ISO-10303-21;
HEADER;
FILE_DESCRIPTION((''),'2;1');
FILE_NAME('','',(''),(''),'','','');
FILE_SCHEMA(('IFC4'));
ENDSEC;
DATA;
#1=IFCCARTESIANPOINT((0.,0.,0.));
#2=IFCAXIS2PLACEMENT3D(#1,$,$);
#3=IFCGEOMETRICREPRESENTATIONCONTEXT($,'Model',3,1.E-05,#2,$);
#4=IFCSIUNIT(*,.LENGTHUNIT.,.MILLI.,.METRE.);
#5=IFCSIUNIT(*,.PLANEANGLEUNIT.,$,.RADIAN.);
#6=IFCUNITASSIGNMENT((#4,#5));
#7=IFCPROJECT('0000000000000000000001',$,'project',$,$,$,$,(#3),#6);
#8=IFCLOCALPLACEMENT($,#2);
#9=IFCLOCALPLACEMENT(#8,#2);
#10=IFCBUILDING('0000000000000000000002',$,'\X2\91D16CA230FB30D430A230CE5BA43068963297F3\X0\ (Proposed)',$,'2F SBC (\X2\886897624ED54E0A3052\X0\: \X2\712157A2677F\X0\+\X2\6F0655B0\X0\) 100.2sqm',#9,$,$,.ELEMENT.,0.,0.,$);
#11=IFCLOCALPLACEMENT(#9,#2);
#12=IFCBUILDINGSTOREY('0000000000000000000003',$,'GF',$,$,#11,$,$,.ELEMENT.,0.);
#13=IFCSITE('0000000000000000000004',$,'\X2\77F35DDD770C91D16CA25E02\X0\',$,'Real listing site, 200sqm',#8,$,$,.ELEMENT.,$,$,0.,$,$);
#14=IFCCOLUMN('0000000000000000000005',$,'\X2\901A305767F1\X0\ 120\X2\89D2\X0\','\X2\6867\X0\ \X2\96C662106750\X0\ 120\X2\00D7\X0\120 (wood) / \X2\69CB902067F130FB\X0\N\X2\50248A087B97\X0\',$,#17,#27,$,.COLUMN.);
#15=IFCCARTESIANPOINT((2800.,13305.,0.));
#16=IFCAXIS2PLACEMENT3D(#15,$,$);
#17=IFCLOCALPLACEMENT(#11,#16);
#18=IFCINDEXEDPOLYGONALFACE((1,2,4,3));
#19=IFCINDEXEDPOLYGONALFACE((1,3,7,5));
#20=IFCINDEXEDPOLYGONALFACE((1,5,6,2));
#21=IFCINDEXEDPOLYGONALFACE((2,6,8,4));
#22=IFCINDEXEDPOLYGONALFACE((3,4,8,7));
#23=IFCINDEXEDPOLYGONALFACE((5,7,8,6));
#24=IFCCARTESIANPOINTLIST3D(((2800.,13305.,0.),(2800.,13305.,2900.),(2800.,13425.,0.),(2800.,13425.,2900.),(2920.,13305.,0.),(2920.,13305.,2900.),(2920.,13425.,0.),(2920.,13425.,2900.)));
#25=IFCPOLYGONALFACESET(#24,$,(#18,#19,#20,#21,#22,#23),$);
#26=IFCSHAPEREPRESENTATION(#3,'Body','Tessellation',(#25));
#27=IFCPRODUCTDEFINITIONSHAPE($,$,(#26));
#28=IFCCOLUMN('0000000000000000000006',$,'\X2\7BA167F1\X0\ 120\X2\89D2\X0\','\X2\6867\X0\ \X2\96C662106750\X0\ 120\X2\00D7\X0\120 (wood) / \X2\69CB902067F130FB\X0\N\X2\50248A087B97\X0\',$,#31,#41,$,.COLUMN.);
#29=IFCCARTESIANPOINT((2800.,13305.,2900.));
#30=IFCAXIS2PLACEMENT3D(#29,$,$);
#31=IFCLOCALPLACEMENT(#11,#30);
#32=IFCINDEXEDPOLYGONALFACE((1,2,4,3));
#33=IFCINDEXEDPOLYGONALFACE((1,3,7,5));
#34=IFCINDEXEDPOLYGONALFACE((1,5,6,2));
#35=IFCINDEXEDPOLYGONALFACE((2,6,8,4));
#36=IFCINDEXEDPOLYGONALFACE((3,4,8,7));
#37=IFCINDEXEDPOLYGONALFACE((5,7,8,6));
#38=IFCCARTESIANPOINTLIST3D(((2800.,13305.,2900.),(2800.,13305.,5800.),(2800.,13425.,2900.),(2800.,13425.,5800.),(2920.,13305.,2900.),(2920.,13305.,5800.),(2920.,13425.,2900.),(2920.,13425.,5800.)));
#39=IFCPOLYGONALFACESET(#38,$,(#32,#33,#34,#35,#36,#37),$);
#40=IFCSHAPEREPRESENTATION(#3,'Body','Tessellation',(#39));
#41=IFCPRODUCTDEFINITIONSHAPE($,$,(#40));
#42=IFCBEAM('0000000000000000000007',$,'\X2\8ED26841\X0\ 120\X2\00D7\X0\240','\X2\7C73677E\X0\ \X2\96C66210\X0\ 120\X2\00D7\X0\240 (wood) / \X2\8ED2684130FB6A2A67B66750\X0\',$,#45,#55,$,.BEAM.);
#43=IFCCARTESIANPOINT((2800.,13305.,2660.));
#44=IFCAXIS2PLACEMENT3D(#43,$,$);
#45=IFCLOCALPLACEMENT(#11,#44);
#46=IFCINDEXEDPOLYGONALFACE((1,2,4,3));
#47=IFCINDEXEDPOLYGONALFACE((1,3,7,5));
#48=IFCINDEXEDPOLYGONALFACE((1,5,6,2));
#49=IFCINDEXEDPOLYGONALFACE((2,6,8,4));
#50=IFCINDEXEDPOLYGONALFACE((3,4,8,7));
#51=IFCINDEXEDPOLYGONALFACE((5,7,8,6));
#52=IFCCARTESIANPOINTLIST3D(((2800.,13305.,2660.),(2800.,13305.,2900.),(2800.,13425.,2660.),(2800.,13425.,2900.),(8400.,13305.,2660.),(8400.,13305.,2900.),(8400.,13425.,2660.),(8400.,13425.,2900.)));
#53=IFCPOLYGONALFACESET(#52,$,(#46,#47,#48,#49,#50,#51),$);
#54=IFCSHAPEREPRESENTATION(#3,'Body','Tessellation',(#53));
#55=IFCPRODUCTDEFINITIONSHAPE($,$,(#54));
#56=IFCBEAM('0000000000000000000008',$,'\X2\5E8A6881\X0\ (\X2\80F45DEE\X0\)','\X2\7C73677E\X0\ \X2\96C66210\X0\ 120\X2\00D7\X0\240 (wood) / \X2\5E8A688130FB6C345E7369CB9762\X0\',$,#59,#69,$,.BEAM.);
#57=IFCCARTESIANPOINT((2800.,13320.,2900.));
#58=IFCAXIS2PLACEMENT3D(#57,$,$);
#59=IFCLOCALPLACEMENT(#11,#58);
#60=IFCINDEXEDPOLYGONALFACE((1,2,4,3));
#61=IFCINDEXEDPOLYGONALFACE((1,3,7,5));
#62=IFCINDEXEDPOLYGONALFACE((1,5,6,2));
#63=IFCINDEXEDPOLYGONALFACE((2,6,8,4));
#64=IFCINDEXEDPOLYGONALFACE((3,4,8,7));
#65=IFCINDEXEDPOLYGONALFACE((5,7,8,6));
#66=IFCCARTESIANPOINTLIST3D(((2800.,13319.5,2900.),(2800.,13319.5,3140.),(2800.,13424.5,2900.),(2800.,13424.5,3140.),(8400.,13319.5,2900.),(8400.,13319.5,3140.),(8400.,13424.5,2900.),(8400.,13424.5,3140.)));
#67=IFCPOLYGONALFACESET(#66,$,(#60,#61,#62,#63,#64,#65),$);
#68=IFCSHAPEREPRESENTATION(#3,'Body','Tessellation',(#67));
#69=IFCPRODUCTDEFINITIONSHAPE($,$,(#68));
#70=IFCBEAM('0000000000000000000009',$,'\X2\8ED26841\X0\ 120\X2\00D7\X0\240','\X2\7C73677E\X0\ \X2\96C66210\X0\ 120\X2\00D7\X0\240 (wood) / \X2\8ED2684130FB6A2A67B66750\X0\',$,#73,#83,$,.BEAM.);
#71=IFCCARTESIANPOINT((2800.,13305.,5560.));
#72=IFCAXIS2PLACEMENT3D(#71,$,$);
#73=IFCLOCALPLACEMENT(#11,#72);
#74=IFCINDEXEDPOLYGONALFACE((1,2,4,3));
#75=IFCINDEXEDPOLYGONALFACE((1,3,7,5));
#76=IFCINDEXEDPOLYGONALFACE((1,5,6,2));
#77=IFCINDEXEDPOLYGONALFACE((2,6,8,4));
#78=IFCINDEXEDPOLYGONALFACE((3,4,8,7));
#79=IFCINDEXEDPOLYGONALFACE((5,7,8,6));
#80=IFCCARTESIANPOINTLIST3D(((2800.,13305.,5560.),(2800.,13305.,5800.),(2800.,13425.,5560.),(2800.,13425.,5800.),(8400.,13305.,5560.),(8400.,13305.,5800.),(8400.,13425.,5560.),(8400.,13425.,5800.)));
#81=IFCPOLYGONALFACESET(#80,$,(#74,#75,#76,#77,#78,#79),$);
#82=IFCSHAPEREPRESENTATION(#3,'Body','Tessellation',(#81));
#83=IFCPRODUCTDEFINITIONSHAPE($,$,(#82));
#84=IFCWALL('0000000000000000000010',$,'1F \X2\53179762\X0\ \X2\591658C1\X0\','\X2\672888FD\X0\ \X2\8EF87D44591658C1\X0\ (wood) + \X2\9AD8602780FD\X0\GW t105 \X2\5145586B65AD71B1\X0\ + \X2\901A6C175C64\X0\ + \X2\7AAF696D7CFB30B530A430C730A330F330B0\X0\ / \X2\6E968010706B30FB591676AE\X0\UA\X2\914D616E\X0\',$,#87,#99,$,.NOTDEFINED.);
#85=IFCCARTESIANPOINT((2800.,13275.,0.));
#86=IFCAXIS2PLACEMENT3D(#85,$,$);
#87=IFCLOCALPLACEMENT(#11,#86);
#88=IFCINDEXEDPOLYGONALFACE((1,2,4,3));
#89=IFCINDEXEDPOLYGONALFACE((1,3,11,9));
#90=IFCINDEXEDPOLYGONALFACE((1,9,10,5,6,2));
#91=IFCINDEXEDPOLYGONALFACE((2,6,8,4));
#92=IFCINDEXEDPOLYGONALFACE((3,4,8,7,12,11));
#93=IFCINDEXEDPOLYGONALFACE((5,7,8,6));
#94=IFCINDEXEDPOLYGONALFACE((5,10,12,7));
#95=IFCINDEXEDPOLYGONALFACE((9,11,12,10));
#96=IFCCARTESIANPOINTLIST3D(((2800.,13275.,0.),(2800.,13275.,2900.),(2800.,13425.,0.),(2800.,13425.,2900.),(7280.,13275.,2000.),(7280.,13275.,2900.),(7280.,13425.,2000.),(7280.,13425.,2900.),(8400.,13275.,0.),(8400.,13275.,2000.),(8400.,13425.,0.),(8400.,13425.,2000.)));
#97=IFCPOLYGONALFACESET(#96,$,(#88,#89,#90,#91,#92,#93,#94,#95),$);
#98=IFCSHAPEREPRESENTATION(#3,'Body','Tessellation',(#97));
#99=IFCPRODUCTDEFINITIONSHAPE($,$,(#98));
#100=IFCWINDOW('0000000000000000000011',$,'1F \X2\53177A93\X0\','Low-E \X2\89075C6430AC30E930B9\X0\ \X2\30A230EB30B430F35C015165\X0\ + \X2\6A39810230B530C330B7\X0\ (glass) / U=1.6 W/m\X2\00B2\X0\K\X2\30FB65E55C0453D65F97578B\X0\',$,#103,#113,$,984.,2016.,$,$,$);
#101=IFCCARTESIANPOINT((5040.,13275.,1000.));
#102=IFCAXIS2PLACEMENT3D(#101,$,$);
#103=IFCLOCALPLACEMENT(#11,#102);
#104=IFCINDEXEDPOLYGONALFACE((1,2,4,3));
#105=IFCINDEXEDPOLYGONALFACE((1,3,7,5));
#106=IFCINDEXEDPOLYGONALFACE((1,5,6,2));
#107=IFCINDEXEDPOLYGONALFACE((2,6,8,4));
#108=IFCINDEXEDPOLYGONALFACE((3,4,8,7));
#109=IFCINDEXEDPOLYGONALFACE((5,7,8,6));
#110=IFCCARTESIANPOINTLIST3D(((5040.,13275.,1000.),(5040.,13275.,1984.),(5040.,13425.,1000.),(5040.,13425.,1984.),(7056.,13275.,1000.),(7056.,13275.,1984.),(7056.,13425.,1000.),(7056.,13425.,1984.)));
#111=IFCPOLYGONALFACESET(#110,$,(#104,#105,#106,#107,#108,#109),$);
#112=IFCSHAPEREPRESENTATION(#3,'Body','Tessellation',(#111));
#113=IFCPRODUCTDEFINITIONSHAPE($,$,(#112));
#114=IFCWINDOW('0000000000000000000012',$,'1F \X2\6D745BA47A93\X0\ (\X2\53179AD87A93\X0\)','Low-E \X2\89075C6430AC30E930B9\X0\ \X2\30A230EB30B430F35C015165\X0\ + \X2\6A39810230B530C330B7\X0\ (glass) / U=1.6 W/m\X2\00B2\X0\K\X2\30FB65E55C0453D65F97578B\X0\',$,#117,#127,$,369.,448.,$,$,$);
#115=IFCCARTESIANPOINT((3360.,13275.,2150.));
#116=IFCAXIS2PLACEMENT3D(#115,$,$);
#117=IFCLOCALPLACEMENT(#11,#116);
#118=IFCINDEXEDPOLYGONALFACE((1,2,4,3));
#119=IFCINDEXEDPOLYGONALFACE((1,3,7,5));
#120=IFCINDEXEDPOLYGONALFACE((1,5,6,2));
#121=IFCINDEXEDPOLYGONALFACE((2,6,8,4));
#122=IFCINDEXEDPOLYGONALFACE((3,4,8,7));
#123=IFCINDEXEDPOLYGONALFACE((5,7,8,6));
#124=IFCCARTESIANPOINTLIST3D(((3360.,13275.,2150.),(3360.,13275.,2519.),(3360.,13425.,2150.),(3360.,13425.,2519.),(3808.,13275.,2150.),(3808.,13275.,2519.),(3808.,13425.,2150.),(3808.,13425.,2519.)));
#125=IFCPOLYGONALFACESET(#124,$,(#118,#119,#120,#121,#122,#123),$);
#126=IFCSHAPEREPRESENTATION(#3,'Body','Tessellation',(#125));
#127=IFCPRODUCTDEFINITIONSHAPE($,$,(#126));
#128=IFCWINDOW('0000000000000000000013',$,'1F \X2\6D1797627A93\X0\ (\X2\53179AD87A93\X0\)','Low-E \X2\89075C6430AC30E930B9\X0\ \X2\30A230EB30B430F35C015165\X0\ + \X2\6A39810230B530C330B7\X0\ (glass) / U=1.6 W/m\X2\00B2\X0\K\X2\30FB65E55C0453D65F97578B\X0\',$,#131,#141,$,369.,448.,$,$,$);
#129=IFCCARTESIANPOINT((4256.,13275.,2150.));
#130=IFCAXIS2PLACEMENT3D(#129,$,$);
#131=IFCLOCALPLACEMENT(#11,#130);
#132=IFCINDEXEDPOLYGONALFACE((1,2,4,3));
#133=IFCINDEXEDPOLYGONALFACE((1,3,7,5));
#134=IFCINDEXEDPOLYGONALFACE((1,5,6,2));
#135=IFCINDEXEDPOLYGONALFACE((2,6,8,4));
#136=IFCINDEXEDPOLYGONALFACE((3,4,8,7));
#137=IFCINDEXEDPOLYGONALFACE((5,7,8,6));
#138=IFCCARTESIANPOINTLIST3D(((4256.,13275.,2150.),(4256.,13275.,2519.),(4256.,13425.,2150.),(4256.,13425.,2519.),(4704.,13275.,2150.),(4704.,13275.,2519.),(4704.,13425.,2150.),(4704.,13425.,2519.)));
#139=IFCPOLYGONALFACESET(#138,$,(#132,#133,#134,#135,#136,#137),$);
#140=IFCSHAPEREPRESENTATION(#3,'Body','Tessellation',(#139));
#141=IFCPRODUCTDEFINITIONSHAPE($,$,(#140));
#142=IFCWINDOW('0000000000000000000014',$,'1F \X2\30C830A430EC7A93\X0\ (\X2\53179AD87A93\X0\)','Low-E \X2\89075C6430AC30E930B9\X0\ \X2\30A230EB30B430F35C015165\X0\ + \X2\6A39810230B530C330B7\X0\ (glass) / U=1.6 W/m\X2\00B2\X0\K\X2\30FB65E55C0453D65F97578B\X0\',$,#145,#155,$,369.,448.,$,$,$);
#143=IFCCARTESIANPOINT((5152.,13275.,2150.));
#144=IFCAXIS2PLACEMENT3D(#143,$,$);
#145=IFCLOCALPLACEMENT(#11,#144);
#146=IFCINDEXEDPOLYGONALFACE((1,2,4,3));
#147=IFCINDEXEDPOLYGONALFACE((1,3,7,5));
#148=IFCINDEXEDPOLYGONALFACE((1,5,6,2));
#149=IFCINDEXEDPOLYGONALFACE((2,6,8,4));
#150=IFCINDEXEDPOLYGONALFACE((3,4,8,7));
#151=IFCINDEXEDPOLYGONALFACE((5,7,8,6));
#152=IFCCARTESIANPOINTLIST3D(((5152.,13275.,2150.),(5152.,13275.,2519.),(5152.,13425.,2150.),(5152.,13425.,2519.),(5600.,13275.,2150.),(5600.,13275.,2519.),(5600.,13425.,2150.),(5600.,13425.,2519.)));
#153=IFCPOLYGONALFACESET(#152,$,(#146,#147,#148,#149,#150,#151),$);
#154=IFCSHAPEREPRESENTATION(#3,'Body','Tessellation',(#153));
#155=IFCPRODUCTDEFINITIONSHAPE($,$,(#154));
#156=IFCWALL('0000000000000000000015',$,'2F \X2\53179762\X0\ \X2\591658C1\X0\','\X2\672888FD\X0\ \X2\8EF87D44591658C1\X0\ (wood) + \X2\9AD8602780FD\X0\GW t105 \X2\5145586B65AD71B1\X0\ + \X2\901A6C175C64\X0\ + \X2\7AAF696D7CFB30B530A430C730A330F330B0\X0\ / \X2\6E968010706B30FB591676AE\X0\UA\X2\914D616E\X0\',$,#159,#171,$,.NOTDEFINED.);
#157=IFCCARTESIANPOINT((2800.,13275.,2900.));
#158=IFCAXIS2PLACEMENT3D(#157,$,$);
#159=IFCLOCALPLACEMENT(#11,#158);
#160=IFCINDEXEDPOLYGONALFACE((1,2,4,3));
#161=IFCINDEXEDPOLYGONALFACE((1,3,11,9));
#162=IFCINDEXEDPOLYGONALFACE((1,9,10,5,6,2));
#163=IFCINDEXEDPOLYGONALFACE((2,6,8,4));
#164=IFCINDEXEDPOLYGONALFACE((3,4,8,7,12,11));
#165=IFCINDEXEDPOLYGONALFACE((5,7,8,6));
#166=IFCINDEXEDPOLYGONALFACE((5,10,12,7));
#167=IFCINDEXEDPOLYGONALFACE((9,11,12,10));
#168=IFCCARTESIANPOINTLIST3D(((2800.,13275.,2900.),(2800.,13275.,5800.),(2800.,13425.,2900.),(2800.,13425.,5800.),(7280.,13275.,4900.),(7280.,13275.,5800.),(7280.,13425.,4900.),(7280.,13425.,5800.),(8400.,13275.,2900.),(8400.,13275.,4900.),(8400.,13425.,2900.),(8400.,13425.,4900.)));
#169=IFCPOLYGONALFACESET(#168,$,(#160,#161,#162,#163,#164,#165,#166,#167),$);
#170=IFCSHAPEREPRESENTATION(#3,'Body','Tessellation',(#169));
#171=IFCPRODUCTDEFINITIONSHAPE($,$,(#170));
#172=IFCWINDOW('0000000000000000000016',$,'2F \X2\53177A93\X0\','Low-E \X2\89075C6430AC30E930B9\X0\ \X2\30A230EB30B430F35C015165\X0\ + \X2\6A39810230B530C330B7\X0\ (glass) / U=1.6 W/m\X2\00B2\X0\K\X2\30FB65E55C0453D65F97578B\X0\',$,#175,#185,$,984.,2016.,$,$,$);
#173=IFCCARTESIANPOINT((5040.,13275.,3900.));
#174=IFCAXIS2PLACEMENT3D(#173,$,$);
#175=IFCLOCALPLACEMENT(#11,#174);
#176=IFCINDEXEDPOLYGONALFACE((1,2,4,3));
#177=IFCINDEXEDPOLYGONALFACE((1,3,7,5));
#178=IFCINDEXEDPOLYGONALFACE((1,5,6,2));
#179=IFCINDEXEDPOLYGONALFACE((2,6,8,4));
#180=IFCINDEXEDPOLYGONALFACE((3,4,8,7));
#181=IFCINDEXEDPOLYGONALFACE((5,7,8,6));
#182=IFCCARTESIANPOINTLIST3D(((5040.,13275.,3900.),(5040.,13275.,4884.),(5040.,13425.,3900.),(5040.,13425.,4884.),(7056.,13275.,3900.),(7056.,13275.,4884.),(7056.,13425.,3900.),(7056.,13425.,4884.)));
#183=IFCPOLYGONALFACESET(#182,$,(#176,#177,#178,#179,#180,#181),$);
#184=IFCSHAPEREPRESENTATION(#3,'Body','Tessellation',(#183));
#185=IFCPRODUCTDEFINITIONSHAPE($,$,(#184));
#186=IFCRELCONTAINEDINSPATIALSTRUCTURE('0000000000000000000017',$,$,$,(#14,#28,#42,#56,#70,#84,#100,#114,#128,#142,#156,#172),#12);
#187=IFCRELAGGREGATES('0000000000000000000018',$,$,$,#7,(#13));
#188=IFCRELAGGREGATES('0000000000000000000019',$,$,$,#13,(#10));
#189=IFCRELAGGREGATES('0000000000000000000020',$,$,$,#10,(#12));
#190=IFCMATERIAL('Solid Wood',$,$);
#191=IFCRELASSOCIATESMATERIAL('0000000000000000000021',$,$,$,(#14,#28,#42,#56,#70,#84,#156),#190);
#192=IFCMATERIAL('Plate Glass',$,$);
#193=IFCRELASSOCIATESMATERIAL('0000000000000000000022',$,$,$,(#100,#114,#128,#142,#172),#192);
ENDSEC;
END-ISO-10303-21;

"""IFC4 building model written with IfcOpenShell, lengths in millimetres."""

from ifc_helpers import new_model, si_unit, frame, frame_2d, origin, place, context, project, spatial, rectangle, extrude, material, element, fill, save


model = new_model("IFC4")

# Units and contexts
model_context = context("Model", 3, precision=1e-05, world=origin())
ifc_project = project(units=[si_unit("LENGTHUNIT", "METRE", prefix="MILLI"), si_unit("PLANEANGLEUNIT", "RADIAN")], contexts=[model_context])

# Site, building, storey
site_placement = place(None, origin())
site = spatial("IfcSite", under=ifc_project, at=site_placement, Name="石川県金沢市", ObjectType="Real listing site, 200sqm", CompositionType="ELEMENT", RefElevation=0.0)
building_placement = place(site_placement, origin())
building = spatial("IfcBuilding", under=site, at=building_placement, Name="金沢・ピアノ室と防音 (Proposed)", ObjectType="2F SBC (表面仕上げ: 無垢板+漆喰) 100.2sqm", CompositionType="ELEMENT", ElevationOfRefHeight=0.0, ElevationOfTerrain=0.0)
storey_placement = place(building_placement, origin())
storey = spatial("IfcBuildingStorey", under=building, at=storey_placement, Name="GF", CompositionType="ELEMENT", Elevation=0.0)

# Columns
ifc_material_1 = material(Name="Solid Wood")
column_1_placement = place(storey_placement, frame((2800.0, 13305.0, 0.0)))
element("IfcColumn", 1, at=column_1_placement, inside=storey, material=ifc_material_1, Name="通し柱 120角", Description="桧 集成材 120×120 (wood) / 構造柱・N値計算", PredefinedType="COLUMN", context=model_context, shape_type="SweptSolid", body=[
    extrude(rectangle(XDim=120.0, YDim=120.0, at=frame_2d((60.0, 60.0))), frame((2800.0, 13305.0, 0.0)), (0.0, 0.0, 1.0), 2900.0),
])
column_2_placement = place(storey_placement, frame((2800.0, 13305.0, 2900.0)))
element("IfcColumn", 2, at=column_2_placement, inside=storey, material=ifc_material_1, Name="管柱 120角", Description="桧 集成材 120×120 (wood) / 構造柱・N値計算", PredefinedType="COLUMN", context=model_context, shape_type="SweptSolid", body=[
    extrude(rectangle(XDim=120.0, YDim=120.0, at=frame_2d((60.0, 60.0))), frame((2800.0, 13305.0, 2900.0)), (0.0, 0.0, 1.0), 2900.0),
])

# Beams
beam_1_placement = place(storey_placement, frame((2800.0, 13305.0, 2660.0)))
element("IfcBeam", 3, at=beam_1_placement, inside=storey, material=ifc_material_1, Name="軒桁 120×240", Description="米松 集成 120×240 (wood) / 軒桁・横架材", PredefinedType="BEAM", context=model_context, shape_type="SweptSolid", body=[
    extrude(rectangle(XDim=5600.0, YDim=120.0, at=frame_2d((2800.0, 60.0))), frame((2800.0, 13305.0, 2660.0)), (0.0, 0.0, 1.0), 240.0),
])
beam_2_placement = place(storey_placement, frame((2800.0, 13320.0, 2900.0)))
element("IfcBeam", 4, at=beam_2_placement, inside=storey, material=ifc_material_1, Name="床梁 (胴差)", Description="米松 集成 120×240 (wood) / 床梁・水平構面", PredefinedType="BEAM", context=model_context, shape_type="SweptSolid", body=[
    extrude(rectangle(XDim=5600.0, YDim=105.0, at=frame_2d((2800.0, 52.0))), frame((2800.0, 13320.0, 2900.0)), (0.0, 0.0, 1.0), 240.0),
])
beam_3_placement = place(storey_placement, frame((2800.0, 13305.0, 5560.0)))
element("IfcBeam", 5, at=beam_3_placement, inside=storey, material=ifc_material_1, Name="軒桁 120×240", Description="米松 集成 120×240 (wood) / 軒桁・横架材", PredefinedType="BEAM", context=model_context, shape_type="SweptSolid", body=[
    extrude(rectangle(XDim=5600.0, YDim=120.0, at=frame_2d((2800.0, 60.0))), frame((2800.0, 13305.0, 5560.0)), (0.0, 0.0, 1.0), 240.0),
])

# Wall, openings, windows
wall_1_placement = place(storey_placement, frame((2800.0, 13275.0, 0.0)))
wall_1 = element("IfcWall", 6, at=wall_1_placement, inside=storey, material=ifc_material_1, Name="1F 北面 外壁", Description="木製 軸組外壁 (wood) + 高性能GW t105 充填断熱 + 通気層 + 窯業系サイディング / 準耐火・外皮UA配慮", PredefinedType="NOTDEFINED", context=model_context, shape_type="SweptSolid", body=[
    extrude(rectangle(XDim=5600.0, YDim=150.0, at=frame_2d((2800.0, 75.0))), frame((2800.0, 13275.0, 0.0)), (0.0, 0.0, 1.0), 2900.0),
])
opening_1_placement = place(storey_placement, frame((5040.0, 13275.0, 1000.0)))
opening_1 = element("IfcOpeningElement", 7, at=opening_1_placement, cuts=wall_1, PredefinedType="NOTDEFINED", context=model_context, shape_type="SweptSolid", body=[
    extrude(rectangle(XDim=2016.0, YDim=150.0, at=frame_2d((1008.0, 75.0))), frame((5040.0, 13275.0, 1000.0)), (0.0, 0.0, 1.0), 984.0),
])
opening_2_placement = place(storey_placement, frame((3360.0, 13275.0, 2150.0)))
opening_2 = element("IfcOpeningElement", 8, at=opening_2_placement, cuts=wall_1, PredefinedType="NOTDEFINED", context=model_context, shape_type="SweptSolid", body=[
    extrude(rectangle(XDim=448.0, YDim=150.0, at=frame_2d((224.0, 75.0))), frame((3360.0, 13275.0, 2150.0)), (0.0, 0.0, 1.0), 369.0),
])
opening_3_placement = place(storey_placement, frame((4256.0, 13275.0, 2150.0)))
opening_3 = element("IfcOpeningElement", 9, at=opening_3_placement, cuts=wall_1, PredefinedType="NOTDEFINED", context=model_context, shape_type="SweptSolid", body=[
    extrude(rectangle(XDim=448.0, YDim=150.0, at=frame_2d((224.0, 75.0))), frame((4256.0, 13275.0, 2150.0)), (0.0, 0.0, 1.0), 369.0),
])
opening_4_placement = place(storey_placement, frame((5152.0, 13275.0, 2150.0)))
opening_4 = element("IfcOpeningElement", 10, at=opening_4_placement, cuts=wall_1, PredefinedType="NOTDEFINED", context=model_context, shape_type="SweptSolid", body=[
    extrude(rectangle(XDim=448.0, YDim=150.0, at=frame_2d((224.0, 75.0))), frame((5152.0, 13275.0, 2150.0)), (0.0, 0.0, 1.0), 369.0),
])
ifc_material_2 = material(Name="Plate Glass")
window_1_placement = place(storey_placement, frame((5040.0, 13275.0, 1000.0)))
window_1 = element("IfcWindow", 11, at=window_1_placement, inside=storey, material=ifc_material_2, Name="1F 北窓", Description="Low-E 複層ガラス アルゴン封入 + 樹脂サッシ (glass) / U=1.6 W/m²K・日射取得型", OverallHeight=984.0, OverallWidth=2016.0, context=model_context, shape_type="SweptSolid", body=[
    extrude(rectangle(XDim=2016.0, YDim=150.0, at=frame_2d((1008.0, 75.0))), frame((5040.0, 13275.0, 1000.0)), (0.0, 0.0, 1.0), 984.0),
])
fill(opening_1, window_1)
window_2_placement = place(storey_placement, frame((3360.0, 13275.0, 2150.0)))
window_2 = element("IfcWindow", 12, at=window_2_placement, inside=storey, material=ifc_material_2, Name="1F 浴室窓 (北高窓)", Description="Low-E 複層ガラス アルゴン封入 + 樹脂サッシ (glass) / U=1.6 W/m²K・日射取得型", OverallHeight=369.0, OverallWidth=448.0, context=model_context, shape_type="SweptSolid", body=[
    extrude(rectangle(XDim=448.0, YDim=150.0, at=frame_2d((224.0, 75.0))), frame((3360.0, 13275.0, 2150.0)), (0.0, 0.0, 1.0), 369.0),
])
fill(opening_2, window_2)
window_3_placement = place(storey_placement, frame((4256.0, 13275.0, 2150.0)))
window_3 = element("IfcWindow", 13, at=window_3_placement, inside=storey, material=ifc_material_2, Name="1F 洗面窓 (北高窓)", Description="Low-E 複層ガラス アルゴン封入 + 樹脂サッシ (glass) / U=1.6 W/m²K・日射取得型", OverallHeight=369.0, OverallWidth=448.0, context=model_context, shape_type="SweptSolid", body=[
    extrude(rectangle(XDim=448.0, YDim=150.0, at=frame_2d((224.0, 75.0))), frame((4256.0, 13275.0, 2150.0)), (0.0, 0.0, 1.0), 369.0),
])
fill(opening_3, window_3)
window_4_placement = place(storey_placement, frame((5152.0, 13275.0, 2150.0)))
window_4 = element("IfcWindow", 14, at=window_4_placement, inside=storey, material=ifc_material_2, Name="1F トイレ窓 (北高窓)", Description="Low-E 複層ガラス アルゴン封入 + 樹脂サッシ (glass) / U=1.6 W/m²K・日射取得型", OverallHeight=369.0, OverallWidth=448.0, context=model_context, shape_type="SweptSolid", body=[
    extrude(rectangle(XDim=448.0, YDim=150.0, at=frame_2d((224.0, 75.0))), frame((5152.0, 13275.0, 2150.0)), (0.0, 0.0, 1.0), 369.0),
])
fill(opening_4, window_4)

# Wall, opening, window
wall_2_placement = place(storey_placement, frame((2800.0, 13275.0, 2900.0)))
wall_2 = element("IfcWall", 15, at=wall_2_placement, inside=storey, material=ifc_material_1, Name="2F 北面 外壁", Description="木製 軸組外壁 (wood) + 高性能GW t105 充填断熱 + 通気層 + 窯業系サイディング / 準耐火・外皮UA配慮", PredefinedType="NOTDEFINED", context=model_context, shape_type="SweptSolid", body=[
    extrude(rectangle(XDim=5600.0, YDim=150.0, at=frame_2d((2800.0, 75.0))), frame((2800.0, 13275.0, 2900.0)), (0.0, 0.0, 1.0), 2900.0),
])
opening_5_placement = place(storey_placement, frame((5040.0, 13275.0, 3900.0)))
opening_5 = element("IfcOpeningElement", 16, at=opening_5_placement, cuts=wall_2, PredefinedType="NOTDEFINED", context=model_context, shape_type="SweptSolid", body=[
    extrude(rectangle(XDim=2016.0, YDim=150.0, at=frame_2d((1008.0, 75.0))), frame((5040.0, 13275.0, 3900.0)), (0.0, 0.0, 1.0), 984.0),
])
window_5_placement = place(storey_placement, frame((5040.0, 13275.0, 3900.0)))
window_5 = element("IfcWindow", 17, at=window_5_placement, inside=storey, material=ifc_material_2, Name="2F 北窓", Description="Low-E 複層ガラス アルゴン封入 + 樹脂サッシ (glass) / U=1.6 W/m²K・日射取得型", OverallHeight=984.0, OverallWidth=2016.0, context=model_context, shape_type="SweptSolid", body=[
    extrude(rectangle(XDim=2016.0, YDim=150.0, at=frame_2d((1008.0, 75.0))), frame((5040.0, 13275.0, 3900.0)), (0.0, 0.0, 1.0), 984.0),
])
fill(opening_5, window_5)

save(model, "model.ifc")
